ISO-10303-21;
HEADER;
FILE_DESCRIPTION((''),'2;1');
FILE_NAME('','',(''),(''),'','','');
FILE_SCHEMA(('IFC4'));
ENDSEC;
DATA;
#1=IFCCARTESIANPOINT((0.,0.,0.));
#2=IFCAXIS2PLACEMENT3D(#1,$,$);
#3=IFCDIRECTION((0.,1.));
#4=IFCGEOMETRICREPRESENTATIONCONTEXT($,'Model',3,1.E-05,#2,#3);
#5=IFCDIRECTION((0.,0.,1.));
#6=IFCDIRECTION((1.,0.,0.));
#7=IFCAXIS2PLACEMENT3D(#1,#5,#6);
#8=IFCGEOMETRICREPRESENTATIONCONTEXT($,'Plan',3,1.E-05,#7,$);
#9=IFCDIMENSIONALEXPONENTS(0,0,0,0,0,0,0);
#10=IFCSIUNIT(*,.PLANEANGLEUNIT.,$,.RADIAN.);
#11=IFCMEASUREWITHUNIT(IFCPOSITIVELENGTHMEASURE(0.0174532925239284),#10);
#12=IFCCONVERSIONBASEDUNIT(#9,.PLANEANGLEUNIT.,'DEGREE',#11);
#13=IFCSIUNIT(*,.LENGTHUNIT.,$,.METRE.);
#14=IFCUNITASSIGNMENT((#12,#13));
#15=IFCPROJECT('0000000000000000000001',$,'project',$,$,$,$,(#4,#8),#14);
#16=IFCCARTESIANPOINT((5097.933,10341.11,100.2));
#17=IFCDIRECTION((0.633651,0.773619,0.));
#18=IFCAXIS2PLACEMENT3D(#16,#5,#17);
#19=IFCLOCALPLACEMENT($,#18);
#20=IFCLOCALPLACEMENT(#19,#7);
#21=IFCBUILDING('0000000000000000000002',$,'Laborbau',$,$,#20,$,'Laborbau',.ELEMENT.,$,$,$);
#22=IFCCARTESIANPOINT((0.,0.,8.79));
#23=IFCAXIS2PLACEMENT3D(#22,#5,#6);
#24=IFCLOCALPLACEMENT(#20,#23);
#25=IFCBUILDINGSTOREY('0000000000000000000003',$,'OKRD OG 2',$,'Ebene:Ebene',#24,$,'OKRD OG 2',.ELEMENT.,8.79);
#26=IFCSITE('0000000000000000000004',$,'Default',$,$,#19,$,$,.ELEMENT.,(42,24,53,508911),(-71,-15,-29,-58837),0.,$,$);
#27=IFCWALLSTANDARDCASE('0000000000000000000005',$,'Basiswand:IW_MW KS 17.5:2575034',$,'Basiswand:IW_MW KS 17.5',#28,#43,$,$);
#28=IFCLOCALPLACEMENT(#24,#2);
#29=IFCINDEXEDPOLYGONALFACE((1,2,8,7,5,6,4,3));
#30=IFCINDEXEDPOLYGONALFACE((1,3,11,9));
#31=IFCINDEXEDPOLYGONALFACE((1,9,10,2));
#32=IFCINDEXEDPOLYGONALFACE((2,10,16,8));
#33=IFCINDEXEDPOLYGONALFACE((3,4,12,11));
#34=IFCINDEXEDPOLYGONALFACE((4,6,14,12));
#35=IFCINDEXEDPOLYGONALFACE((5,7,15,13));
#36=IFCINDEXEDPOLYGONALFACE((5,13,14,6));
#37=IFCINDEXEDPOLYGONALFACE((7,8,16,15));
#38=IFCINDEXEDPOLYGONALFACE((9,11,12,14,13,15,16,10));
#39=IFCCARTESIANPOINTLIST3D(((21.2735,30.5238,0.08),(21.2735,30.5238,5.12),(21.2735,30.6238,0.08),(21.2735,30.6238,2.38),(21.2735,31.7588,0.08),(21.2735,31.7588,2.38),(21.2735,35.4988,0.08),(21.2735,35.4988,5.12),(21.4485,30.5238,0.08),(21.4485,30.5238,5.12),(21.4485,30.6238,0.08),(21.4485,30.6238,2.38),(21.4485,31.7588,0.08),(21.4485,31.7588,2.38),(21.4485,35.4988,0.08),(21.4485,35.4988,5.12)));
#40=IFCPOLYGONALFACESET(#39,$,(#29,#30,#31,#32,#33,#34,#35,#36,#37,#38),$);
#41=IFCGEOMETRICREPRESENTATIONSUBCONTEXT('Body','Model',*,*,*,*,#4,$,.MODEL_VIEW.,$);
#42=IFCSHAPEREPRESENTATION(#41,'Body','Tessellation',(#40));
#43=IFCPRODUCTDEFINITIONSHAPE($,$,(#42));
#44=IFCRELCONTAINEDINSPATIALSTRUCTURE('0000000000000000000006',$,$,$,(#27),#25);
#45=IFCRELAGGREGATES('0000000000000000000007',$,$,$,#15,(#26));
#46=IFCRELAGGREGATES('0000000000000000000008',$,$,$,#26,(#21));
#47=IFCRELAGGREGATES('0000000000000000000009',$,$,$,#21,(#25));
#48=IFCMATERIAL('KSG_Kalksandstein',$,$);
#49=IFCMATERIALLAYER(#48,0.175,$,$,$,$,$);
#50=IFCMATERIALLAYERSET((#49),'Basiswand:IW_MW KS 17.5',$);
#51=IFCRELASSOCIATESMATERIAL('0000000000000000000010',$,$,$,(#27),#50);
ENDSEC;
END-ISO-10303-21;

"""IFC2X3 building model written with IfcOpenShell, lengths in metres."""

from ifc_helpers import new_model, entity, si_unit, converted_unit, direction, frame, frame_2d, origin, origin_with_axes, place, context, subcontext, project, spatial, rectangle, extrude, material, layer, layer_set, layer_usage, element, save


model = new_model("IFC2X3")

# Units and contexts
model_context = context("Model", 3, precision=1e-05, world=origin(), true_north=direction((0.0, 1.0)))
plan_context = context("Plan", 3, precision=1e-05, world=origin_with_axes())
body_context = subcontext(model_context, "Body", "Model", "MODEL_VIEW")
ifc_project = project(units=[converted_unit("PLANEANGLEUNIT", "DEGREE", entity("IfcPositiveLengthMeasure", 0.0174532925239284), si_unit("PLANEANGLEUNIT", "RADIAN"), dimensions=[0, 0, 0, 0, 0, 0, 0]), si_unit("LENGTHUNIT", "METRE")], contexts=[model_context, plan_context])

# Site, building, storey
site_placement = place(None, frame((5097.933, 10341.11, 100.2), z_axis=(0.0, 0.0, 1.0), x_axis=(0.633651, 0.773619, 0.0)))
site = spatial("IfcSite", under=ifc_project, at=site_placement, Name="Default", CompositionType="ELEMENT", RefLatitude=(42, 24, 53, 508911), RefLongitude=(-71, -15, -29, -58837), RefElevation=0.0)
building_placement = place(site_placement, origin_with_axes())
building = spatial("IfcBuilding", under=site, at=building_placement, Name="Laborbau", LongName="Laborbau", CompositionType="ELEMENT")
storey_placement = place(building_placement, frame((0.0, 0.0, 8.79), z_axis=(0.0, 0.0, 1.0), x_axis=(1.0, 0.0, 0.0)))
storey = spatial("IfcBuildingStorey", under=building, at=storey_placement, Name="OKRD OG 2", ObjectType="Ebene:Ebene", LongName="OKRD OG 2", CompositionType="ELEMENT", Elevation=8.79)

# Shared definitions
ifc_material_1 = material(Name="KSG_Kalksandstein")
ifc_layer_1 = layer(ifc_material_1, 0.175)
ifc_layer_set_1 = layer_set([ifc_layer_1], Name="Basiswand:IW_MW KS 17.5")

# Wall, openings
ifc_layer_usage_1 = layer_usage(ifc_layer_set_1, "AXIS2", "NEGATIVE", 0.0875)
wall_1_placement = place(storey_placement, frame((21.361, 30.5238, 0.08), z_axis=(0.0, 0.0, 1.0), x_axis=(0.0, 1.0, 0.0)))
wall_1 = element("IfcWallStandardCase", 1, at=wall_1_placement, inside=storey, material=ifc_layer_usage_1, Name="Basiswand:IW_MW KS 17.5:2575034", ObjectType="Basiswand:IW_MW KS 17.5", context=body_context, shape_type="SweptSolid", body=[
    extrude(rectangle(XDim=4.975, YDim=0.175, at=frame_2d((2.4875, 0.0), x_axis=(-1.0, 0.0))), origin(), (0.0, 0.0, 1.0), 5.04),
])
opening_1_placement = place(wall_1_placement, frame((0.1, -0.0875, -0.08), z_axis=(0.0, 0.0, 1.0), x_axis=(1.0, 0.0, 0.0)))
element("IfcOpeningElement", 2, at=opening_1_placement, cuts=wall_1, ObjectType="Opening", context=body_context, shape_type="SweptSolid", body=[
    extrude(rectangle(XDim=2.38, YDim=1.135, at=frame_2d((1.19, 0.5675), x_axis=(1.0, 0.0))), frame((0.0, 0.0, 0.0), z_axis=(0.0, 1.0, 0.0), x_axis=(0.0, 0.0, 1.0)), (0.0, 0.0, 1.0), 0.175),
])
opening_2_placement = place(wall_1_placement, frame((-30.5238, 21.361, -0.08), z_axis=(0.0, 0.0, 1.0), x_axis=(0.0, -1.0, 0.0)))
element("IfcOpeningElement", 3, at=opening_2_placement, cuts=wall_1, ObjectType="Opening", context=body_context, shape_type="SweptSolid", body=[
    extrude(rectangle(XDim=2.38, YDim=1.135, at=frame_2d((0.0, 0.0), x_axis=(0.0, 1.0))), frame((22.9725, 31.1913, 1.19), z_axis=(-1.0, 0.0, 0.0), x_axis=(0.0, -1.0, 0.0)), (0.0, 0.0, 1.0), 3.048),
])

save(model, "model.ifc")
